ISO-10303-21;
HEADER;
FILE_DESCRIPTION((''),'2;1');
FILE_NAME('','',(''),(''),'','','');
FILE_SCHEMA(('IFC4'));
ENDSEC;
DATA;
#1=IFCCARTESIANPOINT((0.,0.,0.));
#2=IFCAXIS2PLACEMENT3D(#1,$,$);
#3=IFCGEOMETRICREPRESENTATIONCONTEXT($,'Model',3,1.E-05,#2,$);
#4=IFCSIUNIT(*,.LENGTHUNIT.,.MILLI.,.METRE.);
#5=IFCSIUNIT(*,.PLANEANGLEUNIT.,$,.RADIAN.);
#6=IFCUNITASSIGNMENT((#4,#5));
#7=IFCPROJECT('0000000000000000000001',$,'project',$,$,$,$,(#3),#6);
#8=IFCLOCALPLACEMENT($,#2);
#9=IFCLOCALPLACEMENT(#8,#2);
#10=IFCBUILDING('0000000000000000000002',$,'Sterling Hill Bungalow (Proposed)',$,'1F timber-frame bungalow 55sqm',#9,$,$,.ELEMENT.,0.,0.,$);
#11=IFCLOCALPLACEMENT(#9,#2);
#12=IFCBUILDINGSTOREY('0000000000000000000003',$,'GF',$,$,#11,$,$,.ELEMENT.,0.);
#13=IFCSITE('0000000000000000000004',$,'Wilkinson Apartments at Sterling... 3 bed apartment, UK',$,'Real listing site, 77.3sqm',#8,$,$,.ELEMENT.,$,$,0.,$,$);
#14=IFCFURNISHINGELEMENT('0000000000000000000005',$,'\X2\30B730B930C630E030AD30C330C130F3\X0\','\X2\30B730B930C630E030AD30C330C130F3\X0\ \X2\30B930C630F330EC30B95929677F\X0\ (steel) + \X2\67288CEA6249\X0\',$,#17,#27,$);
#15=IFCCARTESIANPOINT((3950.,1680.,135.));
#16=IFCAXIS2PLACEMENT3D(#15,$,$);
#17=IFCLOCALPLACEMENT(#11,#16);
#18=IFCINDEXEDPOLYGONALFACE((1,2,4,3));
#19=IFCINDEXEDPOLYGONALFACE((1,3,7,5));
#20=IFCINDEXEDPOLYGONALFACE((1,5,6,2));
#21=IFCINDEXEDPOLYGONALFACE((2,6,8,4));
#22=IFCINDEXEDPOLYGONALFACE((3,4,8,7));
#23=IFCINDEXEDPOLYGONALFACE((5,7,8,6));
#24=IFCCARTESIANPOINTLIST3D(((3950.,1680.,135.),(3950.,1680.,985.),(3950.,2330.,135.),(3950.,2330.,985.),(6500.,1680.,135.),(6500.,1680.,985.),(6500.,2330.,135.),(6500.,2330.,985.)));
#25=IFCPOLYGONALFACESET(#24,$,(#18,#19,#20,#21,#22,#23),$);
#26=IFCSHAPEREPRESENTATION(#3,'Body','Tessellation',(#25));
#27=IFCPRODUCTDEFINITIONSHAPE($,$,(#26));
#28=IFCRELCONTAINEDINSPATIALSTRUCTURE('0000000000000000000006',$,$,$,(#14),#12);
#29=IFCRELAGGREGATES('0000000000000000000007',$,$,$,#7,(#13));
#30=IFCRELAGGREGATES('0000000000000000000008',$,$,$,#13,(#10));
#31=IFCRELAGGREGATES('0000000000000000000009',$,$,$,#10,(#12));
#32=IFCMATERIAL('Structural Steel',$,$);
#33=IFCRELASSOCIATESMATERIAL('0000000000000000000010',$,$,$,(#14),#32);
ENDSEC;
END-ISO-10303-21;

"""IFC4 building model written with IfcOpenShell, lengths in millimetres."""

from ifc_helpers import new_model, si_unit, frame, frame_2d, origin, place, context, project, spatial, rectangle, extrude, material, element, save


model = new_model("IFC4")

# Units and contexts
model_context = context("Model", 3, precision=1e-05, world=origin())
ifc_project = project(units=[si_unit("LENGTHUNIT", "METRE", prefix="MILLI"), si_unit("PLANEANGLEUNIT", "RADIAN")], contexts=[model_context])

# Site, building, storey
site_placement = place(None, origin())
site = spatial("IfcSite", under=ifc_project, at=site_placement, Name="Wilkinson Apartments at Sterling... 3 bed apartment, UK", ObjectType="Real listing site, 77.3sqm", CompositionType="ELEMENT", RefElevation=0.0)
building_placement = place(site_placement, origin())
building = spatial("IfcBuilding", under=site, at=building_placement, Name="Sterling Hill Bungalow (Proposed)", ObjectType="1F timber-frame bungalow 55sqm", CompositionType="ELEMENT", ElevationOfRefHeight=0.0, ElevationOfTerrain=0.0)
storey_placement = place(building_placement, origin())
storey = spatial("IfcBuildingStorey", under=building, at=storey_placement, Name="GF", CompositionType="ELEMENT", Elevation=0.0)

# Furnishing element
ifc_material_1 = material(Name="Structural Steel")
furnishing_1_placement = place(storey_placement, frame((3950.0, 1680.0, 135.0)))
element("IfcFurnishingElement", 1, at=furnishing_1_placement, inside=storey, material=ifc_material_1, Name="システムキッチン", Description="システムキッチン ステンレス天板 (steel) + 木質扉", context=model_context, shape_type="SweptSolid", body=[
    extrude(rectangle(XDim=2550.0, YDim=650.0, at=frame_2d((1275.0, 325.0))), frame((3950.0, 1680.0, 135.0)), (0.0, 0.0, 1.0), 850.0),
])

save(model, "model.ifc")
